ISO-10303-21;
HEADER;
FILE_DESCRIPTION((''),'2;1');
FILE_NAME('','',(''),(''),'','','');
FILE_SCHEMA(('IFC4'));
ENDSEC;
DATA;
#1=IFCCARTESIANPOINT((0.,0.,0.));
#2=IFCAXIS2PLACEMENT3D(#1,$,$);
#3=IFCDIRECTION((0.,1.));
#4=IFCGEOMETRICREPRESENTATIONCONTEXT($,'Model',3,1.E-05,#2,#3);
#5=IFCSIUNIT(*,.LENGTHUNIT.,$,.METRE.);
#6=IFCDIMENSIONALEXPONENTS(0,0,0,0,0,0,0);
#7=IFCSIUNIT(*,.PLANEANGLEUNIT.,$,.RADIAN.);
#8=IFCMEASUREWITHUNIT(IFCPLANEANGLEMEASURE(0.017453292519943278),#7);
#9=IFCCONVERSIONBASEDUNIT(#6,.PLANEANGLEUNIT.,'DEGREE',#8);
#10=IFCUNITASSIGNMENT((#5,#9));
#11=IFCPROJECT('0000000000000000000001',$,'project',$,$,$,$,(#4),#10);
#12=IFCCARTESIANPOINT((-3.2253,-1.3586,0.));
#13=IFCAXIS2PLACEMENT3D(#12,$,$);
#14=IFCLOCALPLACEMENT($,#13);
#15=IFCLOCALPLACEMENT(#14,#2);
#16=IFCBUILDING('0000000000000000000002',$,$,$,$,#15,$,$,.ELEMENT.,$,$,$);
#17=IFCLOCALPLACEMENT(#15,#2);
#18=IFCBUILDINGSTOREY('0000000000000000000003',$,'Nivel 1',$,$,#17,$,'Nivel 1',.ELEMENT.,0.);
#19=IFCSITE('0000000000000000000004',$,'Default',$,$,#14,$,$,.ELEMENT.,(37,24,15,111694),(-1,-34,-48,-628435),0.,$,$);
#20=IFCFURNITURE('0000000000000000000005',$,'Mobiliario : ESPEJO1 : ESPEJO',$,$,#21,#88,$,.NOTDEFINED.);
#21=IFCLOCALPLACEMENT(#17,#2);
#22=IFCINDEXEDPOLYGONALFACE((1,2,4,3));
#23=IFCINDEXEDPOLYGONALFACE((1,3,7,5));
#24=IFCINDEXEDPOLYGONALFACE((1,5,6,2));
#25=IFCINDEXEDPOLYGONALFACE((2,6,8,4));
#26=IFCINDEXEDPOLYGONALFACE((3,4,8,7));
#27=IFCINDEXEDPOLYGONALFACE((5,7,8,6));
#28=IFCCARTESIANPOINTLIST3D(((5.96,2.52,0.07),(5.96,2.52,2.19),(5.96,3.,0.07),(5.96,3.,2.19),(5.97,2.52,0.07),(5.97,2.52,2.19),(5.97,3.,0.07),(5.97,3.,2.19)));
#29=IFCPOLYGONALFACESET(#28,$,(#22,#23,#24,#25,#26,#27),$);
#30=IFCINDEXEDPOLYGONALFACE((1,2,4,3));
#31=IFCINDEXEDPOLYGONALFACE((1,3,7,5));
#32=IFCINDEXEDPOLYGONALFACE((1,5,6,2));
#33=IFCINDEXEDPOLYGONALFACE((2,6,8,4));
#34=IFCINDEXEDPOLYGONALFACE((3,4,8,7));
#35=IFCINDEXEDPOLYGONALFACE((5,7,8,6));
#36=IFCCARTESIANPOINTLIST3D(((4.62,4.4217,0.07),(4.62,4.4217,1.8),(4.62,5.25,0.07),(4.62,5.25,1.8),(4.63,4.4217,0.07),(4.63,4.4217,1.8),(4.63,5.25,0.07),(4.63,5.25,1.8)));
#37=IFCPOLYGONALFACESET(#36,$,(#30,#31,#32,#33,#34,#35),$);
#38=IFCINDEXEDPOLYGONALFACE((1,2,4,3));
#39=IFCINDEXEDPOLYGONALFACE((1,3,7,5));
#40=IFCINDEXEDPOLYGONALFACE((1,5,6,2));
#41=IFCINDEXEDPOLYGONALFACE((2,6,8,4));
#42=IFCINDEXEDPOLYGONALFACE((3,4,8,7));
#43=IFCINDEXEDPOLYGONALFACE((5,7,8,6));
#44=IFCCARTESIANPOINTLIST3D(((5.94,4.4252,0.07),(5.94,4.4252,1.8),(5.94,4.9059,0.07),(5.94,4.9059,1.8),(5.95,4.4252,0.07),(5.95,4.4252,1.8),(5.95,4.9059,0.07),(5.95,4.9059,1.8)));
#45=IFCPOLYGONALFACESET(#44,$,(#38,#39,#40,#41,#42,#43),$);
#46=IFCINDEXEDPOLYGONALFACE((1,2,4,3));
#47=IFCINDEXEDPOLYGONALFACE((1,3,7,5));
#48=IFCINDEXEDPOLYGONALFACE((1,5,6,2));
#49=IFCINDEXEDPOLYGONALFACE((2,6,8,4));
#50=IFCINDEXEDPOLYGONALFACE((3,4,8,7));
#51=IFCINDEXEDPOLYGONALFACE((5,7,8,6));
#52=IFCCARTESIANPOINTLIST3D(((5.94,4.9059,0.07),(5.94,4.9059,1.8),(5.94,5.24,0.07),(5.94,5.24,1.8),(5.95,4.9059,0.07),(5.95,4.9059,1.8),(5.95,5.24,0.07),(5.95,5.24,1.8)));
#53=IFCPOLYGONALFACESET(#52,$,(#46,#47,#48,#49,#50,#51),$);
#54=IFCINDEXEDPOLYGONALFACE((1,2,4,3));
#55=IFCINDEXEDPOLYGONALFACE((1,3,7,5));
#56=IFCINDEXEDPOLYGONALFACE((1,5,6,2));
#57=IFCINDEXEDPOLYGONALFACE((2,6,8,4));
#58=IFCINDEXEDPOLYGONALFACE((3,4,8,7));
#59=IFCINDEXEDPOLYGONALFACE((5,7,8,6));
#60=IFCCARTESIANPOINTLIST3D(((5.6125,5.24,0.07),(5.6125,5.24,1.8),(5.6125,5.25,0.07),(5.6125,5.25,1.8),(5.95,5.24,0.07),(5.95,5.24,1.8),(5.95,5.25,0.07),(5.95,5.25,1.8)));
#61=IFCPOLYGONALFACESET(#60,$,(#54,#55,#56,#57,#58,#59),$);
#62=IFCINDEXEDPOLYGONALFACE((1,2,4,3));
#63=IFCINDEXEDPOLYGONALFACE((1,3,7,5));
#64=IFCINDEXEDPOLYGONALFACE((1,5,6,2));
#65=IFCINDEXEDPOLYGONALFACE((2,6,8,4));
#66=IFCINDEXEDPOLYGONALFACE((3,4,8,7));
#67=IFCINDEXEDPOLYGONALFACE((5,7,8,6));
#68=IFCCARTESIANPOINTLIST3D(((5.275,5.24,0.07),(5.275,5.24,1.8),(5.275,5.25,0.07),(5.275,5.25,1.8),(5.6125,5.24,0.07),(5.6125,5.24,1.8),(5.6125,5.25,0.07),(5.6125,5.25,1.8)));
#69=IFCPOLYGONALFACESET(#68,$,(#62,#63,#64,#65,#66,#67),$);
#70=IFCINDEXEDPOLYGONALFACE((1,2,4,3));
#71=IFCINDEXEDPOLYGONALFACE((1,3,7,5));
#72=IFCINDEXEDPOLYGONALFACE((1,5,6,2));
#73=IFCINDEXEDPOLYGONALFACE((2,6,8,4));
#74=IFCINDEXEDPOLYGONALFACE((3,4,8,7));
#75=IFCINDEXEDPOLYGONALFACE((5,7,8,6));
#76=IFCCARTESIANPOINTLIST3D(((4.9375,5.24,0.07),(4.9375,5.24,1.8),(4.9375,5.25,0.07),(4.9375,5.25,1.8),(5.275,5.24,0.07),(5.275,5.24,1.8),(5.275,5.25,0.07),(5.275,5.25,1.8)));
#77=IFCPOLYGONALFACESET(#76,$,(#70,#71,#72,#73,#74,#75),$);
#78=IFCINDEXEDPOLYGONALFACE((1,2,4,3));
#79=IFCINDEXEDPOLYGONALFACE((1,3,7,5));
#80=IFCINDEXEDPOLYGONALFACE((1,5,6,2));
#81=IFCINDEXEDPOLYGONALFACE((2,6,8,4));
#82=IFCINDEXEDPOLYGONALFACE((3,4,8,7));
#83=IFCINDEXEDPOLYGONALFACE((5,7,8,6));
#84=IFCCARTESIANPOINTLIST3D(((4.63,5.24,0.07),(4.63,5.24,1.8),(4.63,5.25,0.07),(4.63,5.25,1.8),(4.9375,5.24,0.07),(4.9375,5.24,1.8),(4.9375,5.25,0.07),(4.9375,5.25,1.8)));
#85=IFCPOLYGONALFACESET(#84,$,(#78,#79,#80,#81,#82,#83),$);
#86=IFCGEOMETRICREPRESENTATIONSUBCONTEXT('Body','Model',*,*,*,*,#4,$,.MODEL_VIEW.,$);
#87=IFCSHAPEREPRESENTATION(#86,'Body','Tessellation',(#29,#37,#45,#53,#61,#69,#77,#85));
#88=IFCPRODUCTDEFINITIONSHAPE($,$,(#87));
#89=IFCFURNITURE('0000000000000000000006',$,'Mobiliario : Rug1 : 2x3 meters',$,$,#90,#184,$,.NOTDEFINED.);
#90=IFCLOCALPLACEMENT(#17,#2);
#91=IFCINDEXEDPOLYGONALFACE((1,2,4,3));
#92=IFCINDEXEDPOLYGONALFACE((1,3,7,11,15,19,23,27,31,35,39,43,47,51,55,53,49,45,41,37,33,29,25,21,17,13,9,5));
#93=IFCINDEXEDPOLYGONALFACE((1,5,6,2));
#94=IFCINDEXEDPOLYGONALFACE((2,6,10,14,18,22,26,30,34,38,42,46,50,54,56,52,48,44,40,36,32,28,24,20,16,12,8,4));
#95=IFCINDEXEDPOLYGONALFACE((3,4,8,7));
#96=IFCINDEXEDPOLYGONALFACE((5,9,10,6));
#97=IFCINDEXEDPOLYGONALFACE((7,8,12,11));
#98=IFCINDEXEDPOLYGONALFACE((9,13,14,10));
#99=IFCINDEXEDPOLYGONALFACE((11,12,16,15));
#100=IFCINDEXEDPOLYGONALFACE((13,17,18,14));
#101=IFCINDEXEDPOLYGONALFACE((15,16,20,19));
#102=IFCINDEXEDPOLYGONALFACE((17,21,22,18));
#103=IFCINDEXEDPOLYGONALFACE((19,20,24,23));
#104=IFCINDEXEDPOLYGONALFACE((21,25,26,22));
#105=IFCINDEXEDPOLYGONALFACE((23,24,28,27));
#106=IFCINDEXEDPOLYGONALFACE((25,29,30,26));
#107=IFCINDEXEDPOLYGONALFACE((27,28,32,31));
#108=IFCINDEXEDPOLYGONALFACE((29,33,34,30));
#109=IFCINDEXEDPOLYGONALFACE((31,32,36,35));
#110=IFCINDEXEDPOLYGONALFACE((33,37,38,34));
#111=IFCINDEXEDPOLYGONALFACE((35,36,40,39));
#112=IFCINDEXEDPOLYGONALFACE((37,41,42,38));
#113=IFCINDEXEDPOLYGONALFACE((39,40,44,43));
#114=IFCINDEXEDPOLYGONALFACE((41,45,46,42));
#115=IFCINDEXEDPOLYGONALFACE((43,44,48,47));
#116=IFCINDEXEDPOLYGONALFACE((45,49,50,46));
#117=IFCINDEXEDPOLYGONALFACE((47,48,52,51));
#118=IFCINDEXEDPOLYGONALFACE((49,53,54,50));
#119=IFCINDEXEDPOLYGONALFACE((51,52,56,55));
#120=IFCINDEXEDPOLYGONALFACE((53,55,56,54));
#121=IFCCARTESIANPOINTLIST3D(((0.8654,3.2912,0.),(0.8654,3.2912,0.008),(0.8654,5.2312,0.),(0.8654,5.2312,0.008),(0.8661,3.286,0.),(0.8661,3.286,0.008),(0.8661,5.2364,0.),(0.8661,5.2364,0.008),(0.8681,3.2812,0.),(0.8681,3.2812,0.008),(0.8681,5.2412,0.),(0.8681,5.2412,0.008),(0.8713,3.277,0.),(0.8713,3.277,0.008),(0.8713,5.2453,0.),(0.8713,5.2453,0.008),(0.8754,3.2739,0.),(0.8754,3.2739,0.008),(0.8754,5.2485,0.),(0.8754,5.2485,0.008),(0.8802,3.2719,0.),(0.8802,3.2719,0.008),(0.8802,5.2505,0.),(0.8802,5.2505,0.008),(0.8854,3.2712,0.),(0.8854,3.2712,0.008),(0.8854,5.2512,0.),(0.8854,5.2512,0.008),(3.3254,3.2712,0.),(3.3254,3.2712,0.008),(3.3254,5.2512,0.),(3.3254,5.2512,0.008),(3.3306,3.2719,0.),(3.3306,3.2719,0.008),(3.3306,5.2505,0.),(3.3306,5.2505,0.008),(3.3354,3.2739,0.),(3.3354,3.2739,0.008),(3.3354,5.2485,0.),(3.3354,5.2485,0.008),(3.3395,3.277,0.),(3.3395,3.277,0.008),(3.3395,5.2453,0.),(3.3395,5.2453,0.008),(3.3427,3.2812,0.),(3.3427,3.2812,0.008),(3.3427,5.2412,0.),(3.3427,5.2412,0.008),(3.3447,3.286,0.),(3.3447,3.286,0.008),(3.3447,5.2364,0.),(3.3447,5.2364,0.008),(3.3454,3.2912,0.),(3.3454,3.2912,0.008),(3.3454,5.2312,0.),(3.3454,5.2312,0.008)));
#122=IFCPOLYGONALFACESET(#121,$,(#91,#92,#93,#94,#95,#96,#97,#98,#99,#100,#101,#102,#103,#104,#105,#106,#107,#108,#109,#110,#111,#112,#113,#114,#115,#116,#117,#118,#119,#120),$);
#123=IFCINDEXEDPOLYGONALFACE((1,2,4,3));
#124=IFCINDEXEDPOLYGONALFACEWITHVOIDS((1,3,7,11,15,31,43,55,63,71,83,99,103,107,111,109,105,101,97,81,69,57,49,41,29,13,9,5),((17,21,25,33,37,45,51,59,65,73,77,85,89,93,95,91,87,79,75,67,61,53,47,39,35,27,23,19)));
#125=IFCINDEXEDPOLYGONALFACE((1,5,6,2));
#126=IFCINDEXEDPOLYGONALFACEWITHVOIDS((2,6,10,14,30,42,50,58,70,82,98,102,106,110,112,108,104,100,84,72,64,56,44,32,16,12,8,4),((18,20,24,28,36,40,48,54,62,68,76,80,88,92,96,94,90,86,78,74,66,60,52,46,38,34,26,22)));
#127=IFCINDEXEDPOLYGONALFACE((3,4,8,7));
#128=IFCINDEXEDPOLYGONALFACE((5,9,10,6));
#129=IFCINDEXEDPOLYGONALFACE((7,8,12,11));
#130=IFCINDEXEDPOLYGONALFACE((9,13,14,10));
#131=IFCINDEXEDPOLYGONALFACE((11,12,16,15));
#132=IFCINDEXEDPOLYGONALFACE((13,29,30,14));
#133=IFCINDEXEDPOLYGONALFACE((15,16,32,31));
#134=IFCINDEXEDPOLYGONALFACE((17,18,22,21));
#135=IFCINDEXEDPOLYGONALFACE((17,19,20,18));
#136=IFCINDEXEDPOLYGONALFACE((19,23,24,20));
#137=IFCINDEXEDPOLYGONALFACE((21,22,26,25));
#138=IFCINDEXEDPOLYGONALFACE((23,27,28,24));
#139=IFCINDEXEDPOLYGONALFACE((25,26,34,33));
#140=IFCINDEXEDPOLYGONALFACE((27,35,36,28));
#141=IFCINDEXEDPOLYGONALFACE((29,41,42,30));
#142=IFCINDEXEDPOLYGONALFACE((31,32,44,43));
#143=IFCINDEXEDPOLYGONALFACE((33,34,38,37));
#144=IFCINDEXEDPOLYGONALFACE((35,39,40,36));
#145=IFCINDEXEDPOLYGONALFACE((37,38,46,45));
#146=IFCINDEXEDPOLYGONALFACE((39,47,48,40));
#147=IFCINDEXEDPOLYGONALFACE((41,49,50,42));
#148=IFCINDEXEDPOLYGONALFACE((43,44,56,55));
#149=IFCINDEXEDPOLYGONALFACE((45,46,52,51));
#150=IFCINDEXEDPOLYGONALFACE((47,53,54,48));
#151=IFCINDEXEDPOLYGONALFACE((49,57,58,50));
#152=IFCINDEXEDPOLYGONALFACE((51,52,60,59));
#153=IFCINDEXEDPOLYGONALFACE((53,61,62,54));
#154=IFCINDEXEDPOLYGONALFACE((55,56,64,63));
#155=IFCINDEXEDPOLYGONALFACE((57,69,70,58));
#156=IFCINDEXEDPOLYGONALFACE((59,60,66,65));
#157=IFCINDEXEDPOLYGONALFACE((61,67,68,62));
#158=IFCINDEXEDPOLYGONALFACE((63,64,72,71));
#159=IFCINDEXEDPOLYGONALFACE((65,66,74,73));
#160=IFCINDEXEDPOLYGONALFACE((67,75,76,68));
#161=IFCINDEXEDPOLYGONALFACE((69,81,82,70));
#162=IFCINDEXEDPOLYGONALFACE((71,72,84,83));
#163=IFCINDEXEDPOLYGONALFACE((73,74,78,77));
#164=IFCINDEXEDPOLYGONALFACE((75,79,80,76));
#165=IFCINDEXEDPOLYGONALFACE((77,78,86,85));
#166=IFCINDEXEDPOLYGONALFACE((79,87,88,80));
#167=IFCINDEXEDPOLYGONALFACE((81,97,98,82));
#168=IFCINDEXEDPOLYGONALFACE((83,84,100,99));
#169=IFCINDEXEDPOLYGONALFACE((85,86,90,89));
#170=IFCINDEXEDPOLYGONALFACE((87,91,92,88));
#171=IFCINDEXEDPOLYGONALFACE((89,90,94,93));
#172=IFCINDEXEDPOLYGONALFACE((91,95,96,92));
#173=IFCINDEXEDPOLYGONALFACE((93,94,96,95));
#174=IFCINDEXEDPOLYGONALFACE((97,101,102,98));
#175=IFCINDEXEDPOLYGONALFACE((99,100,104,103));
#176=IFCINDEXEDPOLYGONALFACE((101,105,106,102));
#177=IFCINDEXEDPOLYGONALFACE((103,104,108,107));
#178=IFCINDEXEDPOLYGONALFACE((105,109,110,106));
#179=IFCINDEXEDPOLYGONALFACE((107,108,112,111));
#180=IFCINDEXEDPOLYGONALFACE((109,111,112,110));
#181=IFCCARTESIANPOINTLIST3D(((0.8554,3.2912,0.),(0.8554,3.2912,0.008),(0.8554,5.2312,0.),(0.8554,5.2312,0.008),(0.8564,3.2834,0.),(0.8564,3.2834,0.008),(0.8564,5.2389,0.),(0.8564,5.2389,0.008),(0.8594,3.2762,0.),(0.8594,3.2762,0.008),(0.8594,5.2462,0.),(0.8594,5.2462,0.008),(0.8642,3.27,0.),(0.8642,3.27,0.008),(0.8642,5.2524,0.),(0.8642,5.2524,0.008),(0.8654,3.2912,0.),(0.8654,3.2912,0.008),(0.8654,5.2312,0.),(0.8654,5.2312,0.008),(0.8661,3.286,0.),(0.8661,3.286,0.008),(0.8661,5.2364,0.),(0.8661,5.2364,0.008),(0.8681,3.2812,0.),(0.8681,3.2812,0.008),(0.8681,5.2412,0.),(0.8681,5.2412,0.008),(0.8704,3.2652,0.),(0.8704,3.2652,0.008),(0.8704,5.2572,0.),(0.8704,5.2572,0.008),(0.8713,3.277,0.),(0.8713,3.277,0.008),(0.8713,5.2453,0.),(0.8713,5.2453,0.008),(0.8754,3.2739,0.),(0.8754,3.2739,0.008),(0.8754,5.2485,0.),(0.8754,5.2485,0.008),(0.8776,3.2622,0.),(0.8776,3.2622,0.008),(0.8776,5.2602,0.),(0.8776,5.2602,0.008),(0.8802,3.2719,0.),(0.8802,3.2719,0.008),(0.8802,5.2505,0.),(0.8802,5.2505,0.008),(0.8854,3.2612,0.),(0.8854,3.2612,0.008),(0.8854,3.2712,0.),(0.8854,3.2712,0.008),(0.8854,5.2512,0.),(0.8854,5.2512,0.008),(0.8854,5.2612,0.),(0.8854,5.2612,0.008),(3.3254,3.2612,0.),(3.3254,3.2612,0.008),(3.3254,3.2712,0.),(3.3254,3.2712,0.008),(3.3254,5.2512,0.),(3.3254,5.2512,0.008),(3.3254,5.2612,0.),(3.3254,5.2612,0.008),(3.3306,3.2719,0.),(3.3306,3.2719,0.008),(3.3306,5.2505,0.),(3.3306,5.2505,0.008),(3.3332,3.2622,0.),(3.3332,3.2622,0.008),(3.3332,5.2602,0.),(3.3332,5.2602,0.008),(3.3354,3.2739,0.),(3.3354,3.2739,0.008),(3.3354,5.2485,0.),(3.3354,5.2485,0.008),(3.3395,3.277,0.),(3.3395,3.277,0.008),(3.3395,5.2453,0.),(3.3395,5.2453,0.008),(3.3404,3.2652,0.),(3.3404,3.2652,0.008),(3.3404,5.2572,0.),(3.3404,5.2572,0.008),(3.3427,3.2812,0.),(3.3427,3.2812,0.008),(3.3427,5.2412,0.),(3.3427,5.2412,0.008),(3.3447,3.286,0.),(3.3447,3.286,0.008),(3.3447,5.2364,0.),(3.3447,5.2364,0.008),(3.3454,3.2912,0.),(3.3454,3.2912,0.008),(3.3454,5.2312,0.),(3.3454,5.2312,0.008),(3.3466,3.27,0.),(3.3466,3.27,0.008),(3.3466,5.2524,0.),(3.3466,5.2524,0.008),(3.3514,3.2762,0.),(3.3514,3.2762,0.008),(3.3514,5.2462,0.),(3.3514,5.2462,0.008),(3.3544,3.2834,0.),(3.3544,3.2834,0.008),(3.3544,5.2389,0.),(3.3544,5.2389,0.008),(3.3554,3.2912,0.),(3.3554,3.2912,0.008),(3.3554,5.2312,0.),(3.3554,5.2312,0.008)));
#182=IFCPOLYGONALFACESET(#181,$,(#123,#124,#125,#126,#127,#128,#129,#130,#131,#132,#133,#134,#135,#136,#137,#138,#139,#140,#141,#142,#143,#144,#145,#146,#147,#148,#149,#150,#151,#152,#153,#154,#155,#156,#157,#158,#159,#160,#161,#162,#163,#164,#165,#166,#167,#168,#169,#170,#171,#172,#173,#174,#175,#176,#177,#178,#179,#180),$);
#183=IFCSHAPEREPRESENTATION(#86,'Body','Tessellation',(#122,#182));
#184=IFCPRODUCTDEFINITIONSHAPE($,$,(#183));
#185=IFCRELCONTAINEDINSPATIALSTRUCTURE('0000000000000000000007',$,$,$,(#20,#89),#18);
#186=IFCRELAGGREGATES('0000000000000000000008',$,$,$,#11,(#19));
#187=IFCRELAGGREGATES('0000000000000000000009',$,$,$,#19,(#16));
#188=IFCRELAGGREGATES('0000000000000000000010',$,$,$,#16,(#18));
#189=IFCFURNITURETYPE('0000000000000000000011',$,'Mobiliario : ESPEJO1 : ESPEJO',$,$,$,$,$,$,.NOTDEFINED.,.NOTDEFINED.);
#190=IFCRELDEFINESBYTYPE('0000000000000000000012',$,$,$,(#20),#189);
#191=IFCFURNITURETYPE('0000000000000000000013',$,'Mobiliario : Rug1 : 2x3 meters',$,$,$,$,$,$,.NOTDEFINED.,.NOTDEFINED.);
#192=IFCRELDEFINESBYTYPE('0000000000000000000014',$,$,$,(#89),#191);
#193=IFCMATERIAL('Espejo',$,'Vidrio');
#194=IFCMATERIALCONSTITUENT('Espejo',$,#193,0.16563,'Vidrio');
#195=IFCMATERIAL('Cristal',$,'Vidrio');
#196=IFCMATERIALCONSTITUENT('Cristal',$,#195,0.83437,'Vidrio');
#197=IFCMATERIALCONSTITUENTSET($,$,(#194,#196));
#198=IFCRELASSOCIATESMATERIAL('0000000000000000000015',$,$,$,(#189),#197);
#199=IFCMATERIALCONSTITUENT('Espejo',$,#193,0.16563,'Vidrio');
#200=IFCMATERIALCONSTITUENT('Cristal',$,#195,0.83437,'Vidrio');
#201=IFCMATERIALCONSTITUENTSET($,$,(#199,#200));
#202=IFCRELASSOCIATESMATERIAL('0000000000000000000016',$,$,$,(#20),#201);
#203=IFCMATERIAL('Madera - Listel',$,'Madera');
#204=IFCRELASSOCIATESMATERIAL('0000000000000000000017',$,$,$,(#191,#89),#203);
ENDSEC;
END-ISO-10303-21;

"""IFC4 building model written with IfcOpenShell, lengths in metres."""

from ifc_helpers import new_model, entity, si_unit, converted_unit, direction, frame, origin, place, context, subcontext, project, spatial, line, arc, indexed_curve, outline, extrude, source, transform, mapped, material, constituent, constituent_set, type_object, type_shapes, element, save


model = new_model("IFC4")

# Units and contexts
model_context = context("Model", 3, precision=1e-05, world=origin(), true_north=direction((0.0, 1.0)))
body_context = subcontext(model_context, "Body", "Model", "MODEL_VIEW")
ifc_project = project(units=[si_unit("LENGTHUNIT", "METRE"), converted_unit("PLANEANGLEUNIT", "DEGREE", entity("IfcPlaneAngleMeasure", 0.017453292519943278), si_unit("PLANEANGLEUNIT", "RADIAN"), dimensions=[0, 0, 0, 0, 0, 0, 0])], contexts=[model_context])

# Site, building, storey
site_placement = place(None, frame((-3.2253, -1.3586, 0.0)))
site = spatial("IfcSite", under=ifc_project, at=site_placement, Name="Default", CompositionType="ELEMENT", RefLatitude=(37, 24, 15, 111694), RefLongitude=(-1, -34, -48, -628435), RefElevation=0.0)
building_placement = place(site_placement, origin())
building = spatial("IfcBuilding", under=site, at=building_placement, CompositionType="ELEMENT")
storey_placement = place(building_placement, origin())
storey = spatial("IfcBuildingStorey", under=building, at=storey_placement, Name="Nivel 1", LongName="Nivel 1", CompositionType="ELEMENT", Elevation=0.0)

# Furniture
ifc_material_1 = material(Name="Espejo", Category="Vidrio")
ifc_constituent_1 = constituent(ifc_material_1, Name="Espejo", Category="Vidrio", fraction=0.16563)
ifc_material_2 = material(Name="Cristal", Category="Vidrio")
ifc_constituent_2 = constituent(ifc_material_2, Name="Cristal", Category="Vidrio", fraction=0.83437)
ifc_constituent_set_1 = constituent_set(constituents=[ifc_constituent_1, ifc_constituent_2])
ifc_constituent_3 = constituent(ifc_material_1, Name="Espejo", Category="Vidrio", fraction=0.16563)
ifc_constituent_4 = constituent(ifc_material_2, Name="Cristal", Category="Vidrio", fraction=0.83437)
ifc_constituent_set_2 = constituent_set(constituents=[ifc_constituent_3, ifc_constituent_4])
furniture_type_1 = type_object("IfcFurnitureType", Name="Mobiliario : ESPEJO1 : ESPEJO", AssemblyPlace="NOTDEFINED", PredefinedType="NOTDEFINED", material=ifc_constituent_set_2)
shared_shape_1 = source(origin(), body_context, "Body", "SweptSolid", [
    extrude(outline(indexed_curve([(-0.24, -0.005), (0.24, -0.005), (0.24, 0.005), (-0.24, 0.005), (-0.24, -0.005)], self_intersect=False)), frame((5.965, 2.76, 0.07), z_axis=(0.0, 0.0, 1.0), x_axis=(0.0, -1.0, 0.0)), (0.0, 0.0, 1.0), 2.12),
    extrude(outline(indexed_curve([(-0.4141, -0.005), (0.4141, -0.005), (0.4141, 0.005), (-0.4141, 0.005), (-0.4141, -0.005)], self_intersect=False)), frame((4.625, 4.8359, 0.07), z_axis=(0.0, 0.0, 1.0), x_axis=(0.0, 1.0, 0.0)), (0.0, 0.0, 1.0), 1.73),
    extrude(outline(indexed_curve([(-0.005, -0.2403), (0.005, -0.2403), (0.005, 0.2403), (-0.005, 0.2403), (-0.005, -0.2403)], self_intersect=False)), frame((5.945, 4.6655, 0.07)), (0.0, 0.0, 1.0), 1.73),
    extrude(outline(indexed_curve([(-0.005, -0.1671), (0.005, -0.1671), (0.005, 0.1671), (-0.005, 0.1671), (-0.005, -0.1671)], self_intersect=False)), frame((5.945, 5.0729, 0.07)), (0.0, 0.0, 1.0), 1.73),
    extrude(outline(indexed_curve([(-0.005, -0.1687), (0.005, -0.1687), (0.005, 0.1687), (-0.005, 0.1687), (-0.005, -0.1687)], self_intersect=False)), frame((5.7813, 5.245, 0.07), z_axis=(0.0, 0.0, 1.0), x_axis=(0.0, -1.0, 0.0)), (0.0, 0.0, 1.0), 1.73),
    extrude(outline(indexed_curve([(-0.005, -0.1687), (0.005, -0.1687), (0.005, 0.1687), (-0.005, 0.1687), (-0.005, -0.1687)], self_intersect=False)), frame((5.4438, 5.245, 0.07), z_axis=(0.0, 0.0, 1.0), x_axis=(0.0, -1.0, 0.0)), (0.0, 0.0, 1.0), 1.73),
    extrude(outline(indexed_curve([(-0.005, -0.1687), (0.005, -0.1687), (0.005, 0.1687), (-0.005, 0.1687), (-0.005, -0.1687)], self_intersect=False)), frame((5.1063, 5.245, 0.07), z_axis=(0.0, 0.0, 1.0), x_axis=(0.0, -1.0, 0.0)), (0.0, 0.0, 1.0), 1.73),
    extrude(outline(indexed_curve([(-0.005, -0.1537), (0.005, -0.1537), (0.005, 0.1537), (-0.005, 0.1537), (-0.005, -0.1537)], self_intersect=False)), frame((4.7838, 5.245, 0.07), z_axis=(0.0, 0.0, 1.0), x_axis=(0.0, -1.0, 0.0)), (0.0, 0.0, 1.0), 1.73),
])
type_shapes(furniture_type_1, [shared_shape_1])
furniture_1_placement = place(storey_placement, origin())
element("IfcFurniture", 1, at=furniture_1_placement, inside=storey, type_object=furniture_type_1, material=ifc_constituent_set_1, Name="Mobiliario : ESPEJO1 : ESPEJO", PredefinedType="NOTDEFINED", context=body_context, shape_type="MappedRepresentation", body=[
    mapped(shared_shape_1, transform((0.0, 0.0, 0.0), scale=1.0)),
])
ifc_material_3 = material(Name="Madera - Listel", Category="Madera")
furniture_type_2 = type_object("IfcFurnitureType", Name="Mobiliario : Rug1 : 2x3 meters", AssemblyPlace="NOTDEFINED", PredefinedType="NOTDEFINED", material=ifc_material_3)
shared_shape_2 = source(origin(), body_context, "Body", "SweptSolid", [
    extrude(outline(indexed_curve([(-0.97, -1.24), (0.97, -1.24), (0.9841, -1.2341), (0.99, -1.22), (0.99, 1.22), (0.9841, 1.2341), (0.97, 1.24), (-0.97, 1.24), (-0.9841, 1.2341), (-0.99, 1.22), (-0.99, -1.22), (-0.9841, -1.2341)], segments=[line(1, 2), arc(2, 3, 4), line(4, 5), arc(5, 6, 7), line(7, 8), arc(8, 9, 10), line(10, 11), arc(11, 12, 1)], self_intersect=False)), frame((0.0, 0.0, 0.0), z_axis=(0.0, 0.0, 1.0), x_axis=(-1.0, 0.0, 0.0)), (0.0, 0.0, 1.0), 0.008),
    extrude(outline(indexed_curve([(-0.97, -1.25), (0.97, -1.25), (0.9912, -1.2412), (1.0, -1.22), (1.0, 1.22), (0.9912, 1.2412), (0.97, 1.25), (-0.97, 1.25), (-0.9912, 1.2412), (-1.0, 1.22), (-1.0, -1.22), (-0.9912, -1.2412)], segments=[line(1, 2), arc(2, 3, 4), line(4, 5), arc(5, 6, 7), line(7, 8), arc(8, 9, 10), line(10, 11), arc(11, 12, 1)], self_intersect=False), holes=[indexed_curve([(-0.97, -1.24), (-0.9841, -1.2341), (-0.99, -1.22), (-0.99, 1.22), (-0.9841, 1.2341), (-0.97, 1.24), (0.97, 1.24), (0.9841, 1.2341), (0.99, 1.22), (0.99, -1.22), (0.9841, -1.2341), (0.97, -1.24)], segments=[arc(1, 2, 3), line(3, 4), arc(4, 5, 6), line(6, 7), arc(7, 8, 9), line(9, 10), arc(10, 11, 12), line(12, 1)], self_intersect=False)]), frame((0.0, 0.0, 0.0), z_axis=(0.0, 0.0, 1.0), x_axis=(-1.0, 0.0, 0.0)), (0.0, 0.0, 1.0), 0.008),
])
type_shapes(furniture_type_2, [shared_shape_2])
furniture_2_placement = place(storey_placement, frame((2.1054, 4.2612, 0.0), z_axis=(0.0, 0.0, 1.0), x_axis=(0.0, -1.0, 0.0)))
element("IfcFurniture", 2, at=furniture_2_placement, inside=storey, type_object=furniture_type_2, material=ifc_material_3, Name="Mobiliario : Rug1 : 2x3 meters", PredefinedType="NOTDEFINED", context=body_context, shape_type="MappedRepresentation", body=[
    mapped(shared_shape_2, transform((0.0, 0.0, 0.0), scale=1.0)),
])

save(model, "model.ifc")
